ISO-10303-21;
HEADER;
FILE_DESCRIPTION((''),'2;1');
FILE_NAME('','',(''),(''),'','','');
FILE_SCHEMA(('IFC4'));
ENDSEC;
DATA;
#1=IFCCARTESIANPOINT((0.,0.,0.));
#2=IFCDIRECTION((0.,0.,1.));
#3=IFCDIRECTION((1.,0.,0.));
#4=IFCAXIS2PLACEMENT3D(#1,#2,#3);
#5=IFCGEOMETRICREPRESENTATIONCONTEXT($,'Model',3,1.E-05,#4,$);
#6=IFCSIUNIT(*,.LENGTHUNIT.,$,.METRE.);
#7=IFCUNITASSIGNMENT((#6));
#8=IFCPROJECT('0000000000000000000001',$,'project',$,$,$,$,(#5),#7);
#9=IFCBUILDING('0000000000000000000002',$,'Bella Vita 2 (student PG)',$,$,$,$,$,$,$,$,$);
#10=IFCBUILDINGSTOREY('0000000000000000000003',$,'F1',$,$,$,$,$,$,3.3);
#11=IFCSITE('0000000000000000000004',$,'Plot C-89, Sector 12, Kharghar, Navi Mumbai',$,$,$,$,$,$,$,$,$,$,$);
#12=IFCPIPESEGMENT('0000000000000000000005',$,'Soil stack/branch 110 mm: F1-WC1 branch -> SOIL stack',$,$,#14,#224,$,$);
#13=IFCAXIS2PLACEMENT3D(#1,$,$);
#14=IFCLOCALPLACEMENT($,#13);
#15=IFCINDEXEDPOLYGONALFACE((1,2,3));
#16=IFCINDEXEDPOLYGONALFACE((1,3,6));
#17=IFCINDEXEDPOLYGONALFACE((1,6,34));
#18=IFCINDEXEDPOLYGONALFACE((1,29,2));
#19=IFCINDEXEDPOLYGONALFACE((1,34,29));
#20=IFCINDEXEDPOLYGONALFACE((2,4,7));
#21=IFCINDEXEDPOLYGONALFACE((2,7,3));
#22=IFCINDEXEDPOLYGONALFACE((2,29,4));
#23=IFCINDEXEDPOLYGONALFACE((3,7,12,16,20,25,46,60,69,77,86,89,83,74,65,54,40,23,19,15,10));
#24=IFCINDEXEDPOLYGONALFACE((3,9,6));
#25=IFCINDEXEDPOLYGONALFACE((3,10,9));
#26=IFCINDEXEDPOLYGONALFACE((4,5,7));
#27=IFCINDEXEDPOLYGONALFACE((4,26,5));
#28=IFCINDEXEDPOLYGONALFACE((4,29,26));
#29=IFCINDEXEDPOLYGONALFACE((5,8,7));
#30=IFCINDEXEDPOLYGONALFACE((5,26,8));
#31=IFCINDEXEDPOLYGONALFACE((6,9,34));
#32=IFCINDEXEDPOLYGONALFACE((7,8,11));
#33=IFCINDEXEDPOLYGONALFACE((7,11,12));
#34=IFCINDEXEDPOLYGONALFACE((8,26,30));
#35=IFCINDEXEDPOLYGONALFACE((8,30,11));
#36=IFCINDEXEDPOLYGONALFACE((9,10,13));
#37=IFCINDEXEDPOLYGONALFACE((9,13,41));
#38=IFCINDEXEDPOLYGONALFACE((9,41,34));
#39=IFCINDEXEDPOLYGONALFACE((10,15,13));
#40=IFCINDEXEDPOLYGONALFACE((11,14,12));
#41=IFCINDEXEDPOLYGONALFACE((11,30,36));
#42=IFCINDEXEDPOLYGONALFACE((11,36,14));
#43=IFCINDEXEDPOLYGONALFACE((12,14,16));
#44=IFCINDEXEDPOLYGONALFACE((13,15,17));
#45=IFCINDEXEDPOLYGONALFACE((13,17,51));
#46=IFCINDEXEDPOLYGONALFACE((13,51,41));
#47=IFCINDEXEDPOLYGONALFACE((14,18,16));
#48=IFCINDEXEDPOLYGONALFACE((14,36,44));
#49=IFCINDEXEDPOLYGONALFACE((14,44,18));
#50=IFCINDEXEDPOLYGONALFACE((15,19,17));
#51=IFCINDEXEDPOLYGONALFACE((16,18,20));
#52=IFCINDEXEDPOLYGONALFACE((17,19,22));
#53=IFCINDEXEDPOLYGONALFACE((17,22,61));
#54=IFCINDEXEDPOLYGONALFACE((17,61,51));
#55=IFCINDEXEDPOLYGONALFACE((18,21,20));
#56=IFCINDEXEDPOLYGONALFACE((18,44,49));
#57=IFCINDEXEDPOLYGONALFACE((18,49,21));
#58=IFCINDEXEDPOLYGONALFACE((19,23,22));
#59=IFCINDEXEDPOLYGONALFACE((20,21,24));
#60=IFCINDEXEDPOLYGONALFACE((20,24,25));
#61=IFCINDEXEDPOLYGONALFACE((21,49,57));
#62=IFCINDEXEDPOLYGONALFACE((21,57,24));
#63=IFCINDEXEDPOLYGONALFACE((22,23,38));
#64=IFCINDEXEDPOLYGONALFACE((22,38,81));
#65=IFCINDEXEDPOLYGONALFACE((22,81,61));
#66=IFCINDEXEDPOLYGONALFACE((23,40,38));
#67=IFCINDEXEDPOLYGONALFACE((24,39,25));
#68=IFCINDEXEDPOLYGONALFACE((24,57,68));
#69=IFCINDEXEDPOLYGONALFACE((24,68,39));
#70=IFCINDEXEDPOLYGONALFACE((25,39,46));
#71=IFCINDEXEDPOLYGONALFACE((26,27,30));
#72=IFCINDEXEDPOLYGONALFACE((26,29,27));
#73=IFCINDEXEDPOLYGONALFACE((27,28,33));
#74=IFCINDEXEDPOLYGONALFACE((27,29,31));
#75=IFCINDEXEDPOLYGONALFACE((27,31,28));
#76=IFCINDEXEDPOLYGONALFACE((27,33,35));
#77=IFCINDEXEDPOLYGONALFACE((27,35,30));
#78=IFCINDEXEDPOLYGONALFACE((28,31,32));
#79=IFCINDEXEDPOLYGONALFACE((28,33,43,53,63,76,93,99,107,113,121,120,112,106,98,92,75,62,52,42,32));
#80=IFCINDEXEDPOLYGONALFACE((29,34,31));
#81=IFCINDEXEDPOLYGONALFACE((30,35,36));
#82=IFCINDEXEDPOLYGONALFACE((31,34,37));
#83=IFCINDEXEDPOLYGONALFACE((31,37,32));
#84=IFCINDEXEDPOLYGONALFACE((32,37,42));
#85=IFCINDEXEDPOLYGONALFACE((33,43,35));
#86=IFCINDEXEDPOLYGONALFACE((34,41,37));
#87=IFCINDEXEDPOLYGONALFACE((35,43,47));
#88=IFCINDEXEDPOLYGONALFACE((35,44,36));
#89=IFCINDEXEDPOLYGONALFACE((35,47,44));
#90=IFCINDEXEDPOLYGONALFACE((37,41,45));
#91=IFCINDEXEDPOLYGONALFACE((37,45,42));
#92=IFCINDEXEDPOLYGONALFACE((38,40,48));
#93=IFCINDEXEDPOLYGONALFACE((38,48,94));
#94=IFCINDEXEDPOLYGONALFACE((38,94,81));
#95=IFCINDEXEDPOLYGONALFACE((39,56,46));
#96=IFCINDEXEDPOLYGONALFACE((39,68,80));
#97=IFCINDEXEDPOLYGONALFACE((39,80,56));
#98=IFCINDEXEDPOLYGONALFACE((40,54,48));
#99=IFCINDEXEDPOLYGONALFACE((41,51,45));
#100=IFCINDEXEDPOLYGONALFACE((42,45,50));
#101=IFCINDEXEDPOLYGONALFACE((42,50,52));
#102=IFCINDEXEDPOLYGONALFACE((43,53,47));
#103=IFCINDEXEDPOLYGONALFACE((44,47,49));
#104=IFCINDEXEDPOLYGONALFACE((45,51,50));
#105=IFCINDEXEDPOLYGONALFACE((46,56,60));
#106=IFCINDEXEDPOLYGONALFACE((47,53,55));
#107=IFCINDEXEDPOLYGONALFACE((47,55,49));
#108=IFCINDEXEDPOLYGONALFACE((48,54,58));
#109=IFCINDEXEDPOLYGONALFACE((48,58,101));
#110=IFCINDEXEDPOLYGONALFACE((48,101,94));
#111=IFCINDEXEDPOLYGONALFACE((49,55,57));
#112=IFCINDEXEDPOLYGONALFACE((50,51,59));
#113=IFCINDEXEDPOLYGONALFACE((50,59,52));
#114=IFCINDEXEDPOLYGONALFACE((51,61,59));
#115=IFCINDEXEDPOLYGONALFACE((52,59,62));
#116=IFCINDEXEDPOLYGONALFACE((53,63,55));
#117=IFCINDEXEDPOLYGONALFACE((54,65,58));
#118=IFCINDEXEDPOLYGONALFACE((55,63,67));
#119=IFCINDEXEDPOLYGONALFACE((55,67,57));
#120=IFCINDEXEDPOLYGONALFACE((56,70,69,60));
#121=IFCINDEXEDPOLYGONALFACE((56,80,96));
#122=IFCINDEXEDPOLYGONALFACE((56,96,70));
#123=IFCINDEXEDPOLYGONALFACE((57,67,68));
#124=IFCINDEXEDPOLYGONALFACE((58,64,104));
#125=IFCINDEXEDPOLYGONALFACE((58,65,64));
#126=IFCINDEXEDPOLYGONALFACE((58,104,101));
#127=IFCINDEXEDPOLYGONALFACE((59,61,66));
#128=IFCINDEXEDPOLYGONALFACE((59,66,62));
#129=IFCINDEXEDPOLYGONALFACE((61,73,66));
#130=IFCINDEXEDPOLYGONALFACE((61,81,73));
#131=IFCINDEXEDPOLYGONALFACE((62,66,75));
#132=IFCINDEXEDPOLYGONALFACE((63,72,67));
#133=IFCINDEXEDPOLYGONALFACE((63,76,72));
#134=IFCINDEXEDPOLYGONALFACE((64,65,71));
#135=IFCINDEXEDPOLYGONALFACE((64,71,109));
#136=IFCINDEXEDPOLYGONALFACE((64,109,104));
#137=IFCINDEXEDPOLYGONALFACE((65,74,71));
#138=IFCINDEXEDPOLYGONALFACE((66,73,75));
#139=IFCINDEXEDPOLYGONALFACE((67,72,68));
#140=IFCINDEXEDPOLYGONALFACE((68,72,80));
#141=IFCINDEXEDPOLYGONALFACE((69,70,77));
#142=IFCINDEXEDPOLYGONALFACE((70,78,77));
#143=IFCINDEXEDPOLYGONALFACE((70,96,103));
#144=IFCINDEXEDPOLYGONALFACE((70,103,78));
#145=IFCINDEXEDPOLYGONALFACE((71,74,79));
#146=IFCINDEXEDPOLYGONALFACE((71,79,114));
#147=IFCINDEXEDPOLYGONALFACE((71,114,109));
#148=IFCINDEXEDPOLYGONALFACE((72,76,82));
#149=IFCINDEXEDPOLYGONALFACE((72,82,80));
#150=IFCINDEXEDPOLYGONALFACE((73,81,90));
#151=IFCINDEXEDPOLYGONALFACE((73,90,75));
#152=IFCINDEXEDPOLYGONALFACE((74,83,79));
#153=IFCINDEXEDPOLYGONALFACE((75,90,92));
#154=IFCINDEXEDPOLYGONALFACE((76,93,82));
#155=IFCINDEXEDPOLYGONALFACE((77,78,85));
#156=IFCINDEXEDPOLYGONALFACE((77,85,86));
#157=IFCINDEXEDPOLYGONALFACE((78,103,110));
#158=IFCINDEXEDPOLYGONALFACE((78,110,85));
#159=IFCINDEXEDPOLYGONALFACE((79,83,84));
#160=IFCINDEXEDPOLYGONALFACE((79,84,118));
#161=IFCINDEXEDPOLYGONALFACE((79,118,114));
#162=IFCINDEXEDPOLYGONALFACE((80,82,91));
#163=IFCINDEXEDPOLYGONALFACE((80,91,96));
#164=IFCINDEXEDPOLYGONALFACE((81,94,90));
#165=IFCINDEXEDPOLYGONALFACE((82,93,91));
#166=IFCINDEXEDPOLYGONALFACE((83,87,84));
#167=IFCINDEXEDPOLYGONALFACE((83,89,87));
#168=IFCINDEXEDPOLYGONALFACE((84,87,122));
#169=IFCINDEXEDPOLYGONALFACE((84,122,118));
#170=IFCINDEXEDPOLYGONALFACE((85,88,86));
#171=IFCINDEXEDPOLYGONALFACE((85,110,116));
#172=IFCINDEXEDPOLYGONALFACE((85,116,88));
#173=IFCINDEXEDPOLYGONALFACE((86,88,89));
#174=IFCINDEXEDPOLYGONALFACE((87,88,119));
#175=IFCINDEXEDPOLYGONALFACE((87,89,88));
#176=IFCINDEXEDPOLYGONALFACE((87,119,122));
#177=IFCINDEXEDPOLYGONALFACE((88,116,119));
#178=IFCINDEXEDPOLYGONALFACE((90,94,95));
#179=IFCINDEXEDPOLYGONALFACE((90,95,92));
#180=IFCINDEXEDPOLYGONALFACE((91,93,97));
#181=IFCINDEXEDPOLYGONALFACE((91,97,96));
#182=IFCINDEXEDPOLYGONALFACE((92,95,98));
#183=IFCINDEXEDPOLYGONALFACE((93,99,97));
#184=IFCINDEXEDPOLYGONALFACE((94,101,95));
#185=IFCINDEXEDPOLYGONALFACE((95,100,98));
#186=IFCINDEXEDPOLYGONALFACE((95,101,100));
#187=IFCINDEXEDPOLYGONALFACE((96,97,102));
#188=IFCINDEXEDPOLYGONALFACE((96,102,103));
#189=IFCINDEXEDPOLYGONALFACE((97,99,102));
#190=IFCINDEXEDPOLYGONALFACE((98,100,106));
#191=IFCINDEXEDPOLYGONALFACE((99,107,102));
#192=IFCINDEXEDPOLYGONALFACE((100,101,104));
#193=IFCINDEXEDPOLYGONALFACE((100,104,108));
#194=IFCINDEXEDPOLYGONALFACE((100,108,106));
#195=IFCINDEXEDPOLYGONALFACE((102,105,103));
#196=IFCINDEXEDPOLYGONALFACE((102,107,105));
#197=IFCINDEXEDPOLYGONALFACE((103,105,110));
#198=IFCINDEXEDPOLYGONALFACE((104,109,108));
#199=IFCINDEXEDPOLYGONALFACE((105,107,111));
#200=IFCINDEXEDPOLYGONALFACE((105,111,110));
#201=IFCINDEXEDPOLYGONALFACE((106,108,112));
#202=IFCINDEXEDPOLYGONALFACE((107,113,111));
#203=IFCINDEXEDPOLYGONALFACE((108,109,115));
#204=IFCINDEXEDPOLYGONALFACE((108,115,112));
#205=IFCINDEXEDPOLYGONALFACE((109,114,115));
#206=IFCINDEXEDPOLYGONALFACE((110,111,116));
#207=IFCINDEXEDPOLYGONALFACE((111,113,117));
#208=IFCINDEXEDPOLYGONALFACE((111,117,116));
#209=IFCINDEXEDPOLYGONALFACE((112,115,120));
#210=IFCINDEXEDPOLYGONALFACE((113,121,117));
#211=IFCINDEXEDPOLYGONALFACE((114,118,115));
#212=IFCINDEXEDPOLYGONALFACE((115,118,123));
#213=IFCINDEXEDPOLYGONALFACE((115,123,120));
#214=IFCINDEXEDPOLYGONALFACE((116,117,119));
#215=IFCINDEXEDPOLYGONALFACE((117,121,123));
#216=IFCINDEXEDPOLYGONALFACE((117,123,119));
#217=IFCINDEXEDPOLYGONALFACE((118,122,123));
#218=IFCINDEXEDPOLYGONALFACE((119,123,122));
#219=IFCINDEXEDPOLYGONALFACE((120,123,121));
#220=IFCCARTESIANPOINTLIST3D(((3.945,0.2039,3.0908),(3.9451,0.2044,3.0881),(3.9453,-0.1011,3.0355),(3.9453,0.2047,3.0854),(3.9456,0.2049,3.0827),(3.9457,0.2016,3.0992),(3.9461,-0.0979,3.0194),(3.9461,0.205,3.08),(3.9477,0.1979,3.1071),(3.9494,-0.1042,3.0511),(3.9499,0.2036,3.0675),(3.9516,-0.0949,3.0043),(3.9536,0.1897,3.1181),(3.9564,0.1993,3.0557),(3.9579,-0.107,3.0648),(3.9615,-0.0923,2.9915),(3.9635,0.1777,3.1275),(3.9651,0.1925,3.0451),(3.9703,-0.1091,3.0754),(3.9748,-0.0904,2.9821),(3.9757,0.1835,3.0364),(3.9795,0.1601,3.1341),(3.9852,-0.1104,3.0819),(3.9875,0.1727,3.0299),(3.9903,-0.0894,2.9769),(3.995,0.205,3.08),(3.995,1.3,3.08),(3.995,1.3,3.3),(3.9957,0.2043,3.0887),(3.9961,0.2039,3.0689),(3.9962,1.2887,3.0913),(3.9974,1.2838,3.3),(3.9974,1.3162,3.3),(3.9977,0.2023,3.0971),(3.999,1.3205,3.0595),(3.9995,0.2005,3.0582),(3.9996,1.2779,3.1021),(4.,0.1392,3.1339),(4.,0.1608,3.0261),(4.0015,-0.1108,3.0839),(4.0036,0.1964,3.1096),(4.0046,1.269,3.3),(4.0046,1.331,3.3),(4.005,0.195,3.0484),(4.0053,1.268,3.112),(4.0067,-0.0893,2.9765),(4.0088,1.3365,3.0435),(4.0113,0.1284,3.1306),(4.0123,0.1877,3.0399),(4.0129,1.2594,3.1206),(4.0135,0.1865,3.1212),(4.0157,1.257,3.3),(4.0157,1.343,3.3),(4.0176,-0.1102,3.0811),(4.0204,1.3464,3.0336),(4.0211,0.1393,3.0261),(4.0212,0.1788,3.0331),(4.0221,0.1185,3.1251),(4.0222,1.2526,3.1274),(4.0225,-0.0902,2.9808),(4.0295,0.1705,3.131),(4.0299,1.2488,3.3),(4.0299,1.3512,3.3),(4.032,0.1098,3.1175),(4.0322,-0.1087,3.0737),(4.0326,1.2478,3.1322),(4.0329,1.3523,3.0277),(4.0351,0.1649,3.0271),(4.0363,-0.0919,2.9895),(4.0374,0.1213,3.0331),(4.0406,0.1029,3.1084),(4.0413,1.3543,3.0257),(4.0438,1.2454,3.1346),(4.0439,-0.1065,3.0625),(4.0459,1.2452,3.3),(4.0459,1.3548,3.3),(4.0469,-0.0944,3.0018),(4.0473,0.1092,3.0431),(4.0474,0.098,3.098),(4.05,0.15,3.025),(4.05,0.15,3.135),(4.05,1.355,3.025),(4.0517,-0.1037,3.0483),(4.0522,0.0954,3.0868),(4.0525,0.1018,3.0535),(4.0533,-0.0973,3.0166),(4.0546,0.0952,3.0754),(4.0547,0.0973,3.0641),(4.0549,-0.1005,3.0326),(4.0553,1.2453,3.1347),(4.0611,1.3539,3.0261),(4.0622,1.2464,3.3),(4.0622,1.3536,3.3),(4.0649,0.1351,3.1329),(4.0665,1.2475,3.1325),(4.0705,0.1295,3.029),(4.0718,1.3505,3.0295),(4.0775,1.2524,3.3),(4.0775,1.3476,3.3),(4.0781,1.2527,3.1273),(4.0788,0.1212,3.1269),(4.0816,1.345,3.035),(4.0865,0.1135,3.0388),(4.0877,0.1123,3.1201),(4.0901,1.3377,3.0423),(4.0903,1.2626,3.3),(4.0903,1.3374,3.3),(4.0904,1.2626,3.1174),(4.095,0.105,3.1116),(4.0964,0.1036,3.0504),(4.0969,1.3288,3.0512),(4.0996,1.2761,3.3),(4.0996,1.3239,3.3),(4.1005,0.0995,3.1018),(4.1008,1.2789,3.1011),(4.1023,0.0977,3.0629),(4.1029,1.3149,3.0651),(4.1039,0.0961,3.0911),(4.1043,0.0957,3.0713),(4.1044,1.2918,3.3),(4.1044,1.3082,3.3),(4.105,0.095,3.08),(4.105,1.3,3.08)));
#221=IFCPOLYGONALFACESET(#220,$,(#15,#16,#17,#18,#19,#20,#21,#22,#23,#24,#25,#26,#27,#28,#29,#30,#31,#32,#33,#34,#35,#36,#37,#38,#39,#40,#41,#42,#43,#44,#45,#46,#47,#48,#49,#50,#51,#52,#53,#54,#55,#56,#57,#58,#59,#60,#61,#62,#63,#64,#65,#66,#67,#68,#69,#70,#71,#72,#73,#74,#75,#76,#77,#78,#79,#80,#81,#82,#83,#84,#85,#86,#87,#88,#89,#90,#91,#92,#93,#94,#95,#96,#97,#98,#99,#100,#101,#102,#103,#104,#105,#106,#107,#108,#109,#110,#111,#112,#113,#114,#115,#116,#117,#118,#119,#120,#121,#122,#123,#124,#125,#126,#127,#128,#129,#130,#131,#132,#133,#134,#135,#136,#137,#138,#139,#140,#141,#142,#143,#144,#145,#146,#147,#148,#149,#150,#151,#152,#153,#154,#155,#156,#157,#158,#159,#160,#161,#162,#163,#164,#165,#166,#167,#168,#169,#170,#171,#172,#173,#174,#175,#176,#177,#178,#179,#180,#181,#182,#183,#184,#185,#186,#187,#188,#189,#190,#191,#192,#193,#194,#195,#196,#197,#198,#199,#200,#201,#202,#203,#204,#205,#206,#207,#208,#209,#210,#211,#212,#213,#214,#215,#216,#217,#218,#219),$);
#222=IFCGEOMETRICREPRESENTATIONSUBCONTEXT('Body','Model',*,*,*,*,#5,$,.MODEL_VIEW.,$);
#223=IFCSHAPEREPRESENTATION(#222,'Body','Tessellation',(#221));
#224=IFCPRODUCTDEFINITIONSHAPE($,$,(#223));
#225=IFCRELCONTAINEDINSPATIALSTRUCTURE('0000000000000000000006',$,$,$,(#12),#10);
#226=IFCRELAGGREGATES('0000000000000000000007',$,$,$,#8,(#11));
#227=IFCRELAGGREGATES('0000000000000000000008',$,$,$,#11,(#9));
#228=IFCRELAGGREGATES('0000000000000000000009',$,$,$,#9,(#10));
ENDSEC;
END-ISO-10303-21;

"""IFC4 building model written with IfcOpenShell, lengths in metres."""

from ifc_helpers import new_model, entity, si_unit, origin, origin_with_axes, place, context, subcontext, project, spatial, element, save


model = new_model("IFC4")

# Units and contexts
model_context = context("Model", 3, precision=1e-05, world=origin_with_axes())
body_context = subcontext(model_context, "Body", "Model", "MODEL_VIEW")
ifc_project = project(units=[si_unit("LENGTHUNIT", "METRE")], contexts=[model_context])

# Site, building, storey
site = spatial("IfcSite", under=ifc_project, Name="Plot C-89, Sector 12, Kharghar, Navi Mumbai")
building = spatial("IfcBuilding", under=site, Name="Bella Vita 2 (student PG)")
storey = spatial("IfcBuildingStorey", under=building, Name="F1", Elevation=3.3)

# Pipe segment
pipe_segment_1_placement = place(None, origin())
element("IfcPipeSegment", 1, at=pipe_segment_1_placement, inside=storey, Name="Soil stack/branch 110 mm: F1-WC1 branch -> SOIL stack", context=body_context, shape_type="AdvancedSweptSolid", body=[
    entity("IfcSweptDiskSolid", entity("IfcPolyline", [entity("IfcCartesianPoint", [4.05, 1.3, 3.3]), entity("IfcCartesianPoint", [4.05, 1.3, 3.08]), entity("IfcCartesianPoint", [4.05, 0.15, 3.08]), entity("IfcCartesianPoint", [4.0, 0.15, 3.08]), entity("IfcCartesianPoint", [4.0, -0.1, 3.03])]), 0.055),
])

save(model, "model.ifc")
